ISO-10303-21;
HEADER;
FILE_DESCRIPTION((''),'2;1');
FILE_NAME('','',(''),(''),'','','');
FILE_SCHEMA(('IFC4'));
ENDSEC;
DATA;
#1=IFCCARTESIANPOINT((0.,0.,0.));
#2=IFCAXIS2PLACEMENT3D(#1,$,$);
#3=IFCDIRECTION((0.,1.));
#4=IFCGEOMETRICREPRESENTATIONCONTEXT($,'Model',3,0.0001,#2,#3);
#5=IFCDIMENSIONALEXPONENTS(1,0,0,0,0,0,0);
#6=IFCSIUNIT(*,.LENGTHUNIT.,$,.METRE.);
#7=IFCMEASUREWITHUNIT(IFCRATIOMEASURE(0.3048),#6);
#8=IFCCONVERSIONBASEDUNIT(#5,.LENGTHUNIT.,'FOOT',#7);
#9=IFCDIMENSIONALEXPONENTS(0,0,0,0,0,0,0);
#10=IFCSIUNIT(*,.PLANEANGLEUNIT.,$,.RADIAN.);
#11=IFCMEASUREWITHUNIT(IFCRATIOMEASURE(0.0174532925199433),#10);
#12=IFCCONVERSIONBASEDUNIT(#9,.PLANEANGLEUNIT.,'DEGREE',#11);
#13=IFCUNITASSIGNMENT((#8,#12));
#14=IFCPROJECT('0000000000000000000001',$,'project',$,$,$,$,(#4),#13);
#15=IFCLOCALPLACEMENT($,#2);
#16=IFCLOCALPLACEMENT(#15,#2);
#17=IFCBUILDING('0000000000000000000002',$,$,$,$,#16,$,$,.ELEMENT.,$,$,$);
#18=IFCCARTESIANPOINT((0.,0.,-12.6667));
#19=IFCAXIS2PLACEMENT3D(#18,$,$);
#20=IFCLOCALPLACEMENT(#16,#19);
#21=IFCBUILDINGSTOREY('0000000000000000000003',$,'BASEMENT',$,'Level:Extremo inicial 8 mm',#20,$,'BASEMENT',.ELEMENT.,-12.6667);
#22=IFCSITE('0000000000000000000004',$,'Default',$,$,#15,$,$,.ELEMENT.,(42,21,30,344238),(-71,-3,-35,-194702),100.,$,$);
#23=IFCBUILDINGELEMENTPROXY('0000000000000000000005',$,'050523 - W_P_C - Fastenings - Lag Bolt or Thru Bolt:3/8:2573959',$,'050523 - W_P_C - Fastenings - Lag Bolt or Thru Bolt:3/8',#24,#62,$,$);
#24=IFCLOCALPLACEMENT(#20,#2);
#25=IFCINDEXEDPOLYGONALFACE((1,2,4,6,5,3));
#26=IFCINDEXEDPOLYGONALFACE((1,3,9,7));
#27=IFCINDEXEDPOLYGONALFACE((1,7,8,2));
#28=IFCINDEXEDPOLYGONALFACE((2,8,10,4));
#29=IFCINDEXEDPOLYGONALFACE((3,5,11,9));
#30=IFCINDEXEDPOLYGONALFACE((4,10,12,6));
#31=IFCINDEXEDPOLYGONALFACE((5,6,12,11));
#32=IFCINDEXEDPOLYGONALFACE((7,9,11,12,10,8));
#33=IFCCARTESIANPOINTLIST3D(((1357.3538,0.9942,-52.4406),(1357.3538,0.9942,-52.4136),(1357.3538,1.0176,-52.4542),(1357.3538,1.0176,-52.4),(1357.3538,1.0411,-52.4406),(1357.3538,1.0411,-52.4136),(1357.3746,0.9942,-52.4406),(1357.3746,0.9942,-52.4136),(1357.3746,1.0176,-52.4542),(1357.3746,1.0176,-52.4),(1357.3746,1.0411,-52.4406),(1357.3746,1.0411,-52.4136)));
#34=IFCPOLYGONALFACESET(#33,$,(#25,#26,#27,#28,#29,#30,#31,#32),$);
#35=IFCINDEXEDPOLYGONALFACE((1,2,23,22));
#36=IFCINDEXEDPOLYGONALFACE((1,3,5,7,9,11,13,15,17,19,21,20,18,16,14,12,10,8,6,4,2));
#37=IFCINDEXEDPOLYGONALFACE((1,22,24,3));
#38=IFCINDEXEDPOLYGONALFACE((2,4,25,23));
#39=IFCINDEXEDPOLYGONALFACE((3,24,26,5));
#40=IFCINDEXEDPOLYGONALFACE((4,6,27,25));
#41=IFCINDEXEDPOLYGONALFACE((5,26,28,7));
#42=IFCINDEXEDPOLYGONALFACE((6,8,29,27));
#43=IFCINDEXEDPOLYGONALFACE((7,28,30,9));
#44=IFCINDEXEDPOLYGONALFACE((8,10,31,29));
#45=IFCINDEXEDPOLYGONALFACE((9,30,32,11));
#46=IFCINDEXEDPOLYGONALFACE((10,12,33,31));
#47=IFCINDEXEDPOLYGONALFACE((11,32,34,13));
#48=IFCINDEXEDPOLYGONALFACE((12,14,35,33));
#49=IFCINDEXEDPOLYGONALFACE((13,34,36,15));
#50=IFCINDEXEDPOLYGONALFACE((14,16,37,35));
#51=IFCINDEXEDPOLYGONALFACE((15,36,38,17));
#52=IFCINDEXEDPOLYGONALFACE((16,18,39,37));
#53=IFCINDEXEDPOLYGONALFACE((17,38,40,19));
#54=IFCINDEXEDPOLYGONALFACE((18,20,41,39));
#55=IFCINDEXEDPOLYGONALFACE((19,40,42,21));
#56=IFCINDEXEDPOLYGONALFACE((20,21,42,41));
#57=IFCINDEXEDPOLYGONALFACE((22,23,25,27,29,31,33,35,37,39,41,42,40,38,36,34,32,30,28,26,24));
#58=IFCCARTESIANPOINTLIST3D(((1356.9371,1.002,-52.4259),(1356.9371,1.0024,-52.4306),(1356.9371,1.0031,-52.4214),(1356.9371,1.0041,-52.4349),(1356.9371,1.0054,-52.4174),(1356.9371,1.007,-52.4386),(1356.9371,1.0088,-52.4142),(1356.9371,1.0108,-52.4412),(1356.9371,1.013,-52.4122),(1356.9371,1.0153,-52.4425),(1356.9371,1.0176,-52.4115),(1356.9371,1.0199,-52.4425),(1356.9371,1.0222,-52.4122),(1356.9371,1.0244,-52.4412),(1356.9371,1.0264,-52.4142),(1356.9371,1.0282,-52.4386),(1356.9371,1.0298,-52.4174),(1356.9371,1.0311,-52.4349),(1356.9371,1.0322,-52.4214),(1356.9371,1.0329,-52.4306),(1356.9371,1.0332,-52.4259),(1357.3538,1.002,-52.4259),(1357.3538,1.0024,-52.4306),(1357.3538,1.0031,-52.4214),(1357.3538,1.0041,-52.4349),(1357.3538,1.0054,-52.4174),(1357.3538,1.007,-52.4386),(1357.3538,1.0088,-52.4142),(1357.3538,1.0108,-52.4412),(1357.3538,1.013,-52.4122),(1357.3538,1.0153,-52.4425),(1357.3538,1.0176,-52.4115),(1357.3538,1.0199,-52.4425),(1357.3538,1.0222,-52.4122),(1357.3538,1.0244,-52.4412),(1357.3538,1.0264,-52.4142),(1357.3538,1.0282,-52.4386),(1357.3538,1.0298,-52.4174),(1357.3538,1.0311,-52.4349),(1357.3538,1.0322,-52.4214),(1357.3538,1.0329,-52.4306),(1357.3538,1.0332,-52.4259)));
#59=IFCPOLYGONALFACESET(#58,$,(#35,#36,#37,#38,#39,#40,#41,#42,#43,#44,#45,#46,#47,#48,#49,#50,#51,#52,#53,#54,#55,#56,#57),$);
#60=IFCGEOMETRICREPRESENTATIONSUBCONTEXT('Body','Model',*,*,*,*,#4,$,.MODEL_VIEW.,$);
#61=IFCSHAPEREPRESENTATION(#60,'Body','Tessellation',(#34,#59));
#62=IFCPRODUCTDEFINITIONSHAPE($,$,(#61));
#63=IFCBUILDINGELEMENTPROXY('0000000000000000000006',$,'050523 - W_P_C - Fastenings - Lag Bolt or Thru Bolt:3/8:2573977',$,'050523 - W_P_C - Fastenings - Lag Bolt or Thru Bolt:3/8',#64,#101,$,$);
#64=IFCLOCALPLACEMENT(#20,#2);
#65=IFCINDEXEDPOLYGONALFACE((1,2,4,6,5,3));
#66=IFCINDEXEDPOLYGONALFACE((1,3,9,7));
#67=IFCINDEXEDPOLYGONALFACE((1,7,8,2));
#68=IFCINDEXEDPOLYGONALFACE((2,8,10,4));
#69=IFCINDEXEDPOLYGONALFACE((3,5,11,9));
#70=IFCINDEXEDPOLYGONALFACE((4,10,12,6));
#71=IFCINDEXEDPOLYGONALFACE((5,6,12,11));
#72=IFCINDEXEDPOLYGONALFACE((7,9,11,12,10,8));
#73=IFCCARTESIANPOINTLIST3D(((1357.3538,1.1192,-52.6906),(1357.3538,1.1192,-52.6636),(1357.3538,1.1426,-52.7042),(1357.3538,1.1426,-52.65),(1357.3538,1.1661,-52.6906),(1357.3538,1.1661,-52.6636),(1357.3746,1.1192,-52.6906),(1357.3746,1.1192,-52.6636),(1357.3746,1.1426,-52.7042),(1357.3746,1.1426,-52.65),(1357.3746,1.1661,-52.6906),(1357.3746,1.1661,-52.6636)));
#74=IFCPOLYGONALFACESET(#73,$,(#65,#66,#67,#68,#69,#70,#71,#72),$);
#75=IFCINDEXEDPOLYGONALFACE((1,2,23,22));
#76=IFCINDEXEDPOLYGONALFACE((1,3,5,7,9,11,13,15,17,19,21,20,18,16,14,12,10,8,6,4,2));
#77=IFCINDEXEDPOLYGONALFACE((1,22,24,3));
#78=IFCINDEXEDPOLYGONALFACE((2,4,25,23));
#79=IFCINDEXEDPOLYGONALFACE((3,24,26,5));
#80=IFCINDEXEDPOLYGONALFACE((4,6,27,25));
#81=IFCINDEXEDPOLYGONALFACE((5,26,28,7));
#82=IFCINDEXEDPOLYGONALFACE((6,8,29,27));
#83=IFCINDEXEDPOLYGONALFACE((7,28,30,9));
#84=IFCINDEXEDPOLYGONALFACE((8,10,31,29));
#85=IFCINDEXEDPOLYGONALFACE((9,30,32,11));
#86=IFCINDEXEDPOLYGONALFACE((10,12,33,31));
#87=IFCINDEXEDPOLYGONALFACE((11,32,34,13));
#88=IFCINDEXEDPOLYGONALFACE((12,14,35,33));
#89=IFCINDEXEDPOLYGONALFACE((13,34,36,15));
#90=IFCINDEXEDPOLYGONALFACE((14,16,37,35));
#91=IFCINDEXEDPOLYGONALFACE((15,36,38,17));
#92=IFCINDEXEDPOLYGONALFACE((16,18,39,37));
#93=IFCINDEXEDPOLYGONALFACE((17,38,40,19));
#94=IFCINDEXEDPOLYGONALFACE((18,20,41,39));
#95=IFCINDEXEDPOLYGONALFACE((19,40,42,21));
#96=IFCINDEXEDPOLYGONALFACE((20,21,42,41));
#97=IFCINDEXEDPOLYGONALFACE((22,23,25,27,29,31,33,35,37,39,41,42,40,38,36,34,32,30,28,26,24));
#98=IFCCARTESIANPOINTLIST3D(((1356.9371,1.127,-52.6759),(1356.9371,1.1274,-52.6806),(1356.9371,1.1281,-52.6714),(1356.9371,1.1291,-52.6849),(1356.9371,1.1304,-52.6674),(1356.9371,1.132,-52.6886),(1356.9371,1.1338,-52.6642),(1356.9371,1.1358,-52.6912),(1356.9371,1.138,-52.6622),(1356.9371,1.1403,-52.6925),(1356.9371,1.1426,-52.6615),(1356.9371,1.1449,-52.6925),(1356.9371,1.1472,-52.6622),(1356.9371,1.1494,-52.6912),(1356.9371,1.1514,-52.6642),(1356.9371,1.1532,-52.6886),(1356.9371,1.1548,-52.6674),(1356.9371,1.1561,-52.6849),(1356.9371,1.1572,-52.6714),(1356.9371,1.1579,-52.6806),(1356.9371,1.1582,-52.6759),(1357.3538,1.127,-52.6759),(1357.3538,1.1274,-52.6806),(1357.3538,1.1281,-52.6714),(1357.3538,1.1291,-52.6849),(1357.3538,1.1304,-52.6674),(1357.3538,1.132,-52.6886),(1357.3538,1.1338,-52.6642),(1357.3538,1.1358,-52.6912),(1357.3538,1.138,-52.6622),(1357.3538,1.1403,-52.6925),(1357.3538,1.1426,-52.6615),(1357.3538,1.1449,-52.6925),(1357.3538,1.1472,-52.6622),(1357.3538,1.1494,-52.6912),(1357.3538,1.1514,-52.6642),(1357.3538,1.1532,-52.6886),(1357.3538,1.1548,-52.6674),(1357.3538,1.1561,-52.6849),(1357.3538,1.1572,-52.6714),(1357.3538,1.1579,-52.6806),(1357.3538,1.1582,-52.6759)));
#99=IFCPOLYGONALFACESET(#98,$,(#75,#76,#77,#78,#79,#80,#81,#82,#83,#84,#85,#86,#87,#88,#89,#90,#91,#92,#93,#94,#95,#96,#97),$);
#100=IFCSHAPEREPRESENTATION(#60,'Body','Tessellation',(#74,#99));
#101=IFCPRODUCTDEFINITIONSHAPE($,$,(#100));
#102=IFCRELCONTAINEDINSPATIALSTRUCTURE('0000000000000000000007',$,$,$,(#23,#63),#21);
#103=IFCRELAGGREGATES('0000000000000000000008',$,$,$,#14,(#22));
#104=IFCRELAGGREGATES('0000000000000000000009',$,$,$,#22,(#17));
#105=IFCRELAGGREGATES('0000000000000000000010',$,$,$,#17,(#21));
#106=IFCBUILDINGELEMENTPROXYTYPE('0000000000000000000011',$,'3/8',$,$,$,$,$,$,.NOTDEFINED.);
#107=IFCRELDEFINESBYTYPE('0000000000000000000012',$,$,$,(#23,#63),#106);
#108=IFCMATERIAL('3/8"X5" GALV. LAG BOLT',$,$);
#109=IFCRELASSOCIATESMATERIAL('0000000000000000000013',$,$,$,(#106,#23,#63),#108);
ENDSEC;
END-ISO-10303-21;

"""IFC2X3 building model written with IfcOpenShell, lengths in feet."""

from ifc_helpers import new_model, entity, si_unit, converted_unit, direction, frame, frame_2d, origin, place, context, subcontext, project, spatial, polyline, circle, outline, extrude, source, transform, mapped, material, type_object, type_shapes, element, save


model = new_model("IFC2X3")

# Units and contexts
model_context = context("Model", 3, precision=0.0001, world=origin(), true_north=direction((0.0, 1.0)))
body_context = subcontext(model_context, "Body", "Model", "MODEL_VIEW")
ifc_project = project(units=[converted_unit("LENGTHUNIT", "FOOT", entity("IfcRatioMeasure", 0.3048), si_unit("LENGTHUNIT", "METRE"), dimensions=[1, 0, 0, 0, 0, 0, 0]), converted_unit("PLANEANGLEUNIT", "DEGREE", entity("IfcRatioMeasure", 0.0174532925199433), si_unit("PLANEANGLEUNIT", "RADIAN"), dimensions=[0, 0, 0, 0, 0, 0, 0])], contexts=[model_context])

# Site, building, storey
site_placement = place(None, origin())
site = spatial("IfcSite", under=ifc_project, at=site_placement, Name="Default", CompositionType="ELEMENT", RefLatitude=(42, 21, 30, 344238), RefLongitude=(-71, -3, -35, -194702), RefElevation=100.0)
building_placement = place(site_placement, origin())
building = spatial("IfcBuilding", under=site, at=building_placement, CompositionType="ELEMENT")
storey_placement = place(building_placement, frame((0.0, 0.0, -12.6667)))
storey = spatial("IfcBuildingStorey", under=building, at=storey_placement, Name="BASEMENT", ObjectType="Level:Extremo inicial 8 mm", LongName="BASEMENT", CompositionType="ELEMENT", Elevation=-12.6667)

# Building element proxies
ifc_material_1 = material(Name="3/8\"X5\" GALV. LAG BOLT")
building_element_proxy_type_1 = type_object("IfcBuildingElementProxyType", Name="3/8", PredefinedType="NOTDEFINED", material=ifc_material_1)
shared_shape_1 = source(origin(), body_context, "Body", "SweptSolid", [
    extrude(outline(polyline([(-0.0135, -0.0234), (0.0135, -0.0234), (0.0271, 0.0), (0.0135, 0.0234), (-0.0135, 0.0234), (-0.0271, 0.0), (-0.0135, -0.0234)])), frame((0.0, 0.0, 0.0), z_axis=(0.0, 0.0, 1.0), x_axis=(0.0, -1.0, 0.0)), (0.0, 0.0, 1.0), 0.0208),
    extrude(circle(Radius=0.0156, at=frame_2d((0.0, 0.0), x_axis=(1.0, 0.0))), frame((0.0, 0.0, -0.4167), z_axis=(0.0, 0.0, 1.0), x_axis=(0.0, 1.0, 0.0)), (0.0, 0.0, 1.0), 0.4167),
])
type_shapes(building_element_proxy_type_1, [shared_shape_1])
for number, where, z_axis, x_axis, name in (
    (1, (1357.3538, 1.0176, -52.4271), (1.0, 0.0, 0.0), (0.0, 1.0, 0.0), "050523 - W_P_C - Fastenings - Lag Bolt or Thru Bolt:3/8:2573959"),
    (2, (1357.3538, 1.1426, -52.6771), (1.0, 0.0, 0.0), (0.0, 1.0, 0.0), "050523 - W_P_C - Fastenings - Lag Bolt or Thru Bolt:3/8:2573977"),
):
    element("IfcBuildingElementProxy", number, at=place(storey_placement, frame(where, z_axis=z_axis, x_axis=x_axis)), inside=storey, type_object=building_element_proxy_type_1, material=ifc_material_1, Name=name, ObjectType="050523 - W_P_C - Fastenings - Lag Bolt or Thru Bolt:3/8", context=body_context, shape_type="MappedRepresentation", body=[
        mapped(shared_shape_1, transform((0.0, 0.0, 0.0), scale=1.0)),
    ])

save(model, "model.ifc")
